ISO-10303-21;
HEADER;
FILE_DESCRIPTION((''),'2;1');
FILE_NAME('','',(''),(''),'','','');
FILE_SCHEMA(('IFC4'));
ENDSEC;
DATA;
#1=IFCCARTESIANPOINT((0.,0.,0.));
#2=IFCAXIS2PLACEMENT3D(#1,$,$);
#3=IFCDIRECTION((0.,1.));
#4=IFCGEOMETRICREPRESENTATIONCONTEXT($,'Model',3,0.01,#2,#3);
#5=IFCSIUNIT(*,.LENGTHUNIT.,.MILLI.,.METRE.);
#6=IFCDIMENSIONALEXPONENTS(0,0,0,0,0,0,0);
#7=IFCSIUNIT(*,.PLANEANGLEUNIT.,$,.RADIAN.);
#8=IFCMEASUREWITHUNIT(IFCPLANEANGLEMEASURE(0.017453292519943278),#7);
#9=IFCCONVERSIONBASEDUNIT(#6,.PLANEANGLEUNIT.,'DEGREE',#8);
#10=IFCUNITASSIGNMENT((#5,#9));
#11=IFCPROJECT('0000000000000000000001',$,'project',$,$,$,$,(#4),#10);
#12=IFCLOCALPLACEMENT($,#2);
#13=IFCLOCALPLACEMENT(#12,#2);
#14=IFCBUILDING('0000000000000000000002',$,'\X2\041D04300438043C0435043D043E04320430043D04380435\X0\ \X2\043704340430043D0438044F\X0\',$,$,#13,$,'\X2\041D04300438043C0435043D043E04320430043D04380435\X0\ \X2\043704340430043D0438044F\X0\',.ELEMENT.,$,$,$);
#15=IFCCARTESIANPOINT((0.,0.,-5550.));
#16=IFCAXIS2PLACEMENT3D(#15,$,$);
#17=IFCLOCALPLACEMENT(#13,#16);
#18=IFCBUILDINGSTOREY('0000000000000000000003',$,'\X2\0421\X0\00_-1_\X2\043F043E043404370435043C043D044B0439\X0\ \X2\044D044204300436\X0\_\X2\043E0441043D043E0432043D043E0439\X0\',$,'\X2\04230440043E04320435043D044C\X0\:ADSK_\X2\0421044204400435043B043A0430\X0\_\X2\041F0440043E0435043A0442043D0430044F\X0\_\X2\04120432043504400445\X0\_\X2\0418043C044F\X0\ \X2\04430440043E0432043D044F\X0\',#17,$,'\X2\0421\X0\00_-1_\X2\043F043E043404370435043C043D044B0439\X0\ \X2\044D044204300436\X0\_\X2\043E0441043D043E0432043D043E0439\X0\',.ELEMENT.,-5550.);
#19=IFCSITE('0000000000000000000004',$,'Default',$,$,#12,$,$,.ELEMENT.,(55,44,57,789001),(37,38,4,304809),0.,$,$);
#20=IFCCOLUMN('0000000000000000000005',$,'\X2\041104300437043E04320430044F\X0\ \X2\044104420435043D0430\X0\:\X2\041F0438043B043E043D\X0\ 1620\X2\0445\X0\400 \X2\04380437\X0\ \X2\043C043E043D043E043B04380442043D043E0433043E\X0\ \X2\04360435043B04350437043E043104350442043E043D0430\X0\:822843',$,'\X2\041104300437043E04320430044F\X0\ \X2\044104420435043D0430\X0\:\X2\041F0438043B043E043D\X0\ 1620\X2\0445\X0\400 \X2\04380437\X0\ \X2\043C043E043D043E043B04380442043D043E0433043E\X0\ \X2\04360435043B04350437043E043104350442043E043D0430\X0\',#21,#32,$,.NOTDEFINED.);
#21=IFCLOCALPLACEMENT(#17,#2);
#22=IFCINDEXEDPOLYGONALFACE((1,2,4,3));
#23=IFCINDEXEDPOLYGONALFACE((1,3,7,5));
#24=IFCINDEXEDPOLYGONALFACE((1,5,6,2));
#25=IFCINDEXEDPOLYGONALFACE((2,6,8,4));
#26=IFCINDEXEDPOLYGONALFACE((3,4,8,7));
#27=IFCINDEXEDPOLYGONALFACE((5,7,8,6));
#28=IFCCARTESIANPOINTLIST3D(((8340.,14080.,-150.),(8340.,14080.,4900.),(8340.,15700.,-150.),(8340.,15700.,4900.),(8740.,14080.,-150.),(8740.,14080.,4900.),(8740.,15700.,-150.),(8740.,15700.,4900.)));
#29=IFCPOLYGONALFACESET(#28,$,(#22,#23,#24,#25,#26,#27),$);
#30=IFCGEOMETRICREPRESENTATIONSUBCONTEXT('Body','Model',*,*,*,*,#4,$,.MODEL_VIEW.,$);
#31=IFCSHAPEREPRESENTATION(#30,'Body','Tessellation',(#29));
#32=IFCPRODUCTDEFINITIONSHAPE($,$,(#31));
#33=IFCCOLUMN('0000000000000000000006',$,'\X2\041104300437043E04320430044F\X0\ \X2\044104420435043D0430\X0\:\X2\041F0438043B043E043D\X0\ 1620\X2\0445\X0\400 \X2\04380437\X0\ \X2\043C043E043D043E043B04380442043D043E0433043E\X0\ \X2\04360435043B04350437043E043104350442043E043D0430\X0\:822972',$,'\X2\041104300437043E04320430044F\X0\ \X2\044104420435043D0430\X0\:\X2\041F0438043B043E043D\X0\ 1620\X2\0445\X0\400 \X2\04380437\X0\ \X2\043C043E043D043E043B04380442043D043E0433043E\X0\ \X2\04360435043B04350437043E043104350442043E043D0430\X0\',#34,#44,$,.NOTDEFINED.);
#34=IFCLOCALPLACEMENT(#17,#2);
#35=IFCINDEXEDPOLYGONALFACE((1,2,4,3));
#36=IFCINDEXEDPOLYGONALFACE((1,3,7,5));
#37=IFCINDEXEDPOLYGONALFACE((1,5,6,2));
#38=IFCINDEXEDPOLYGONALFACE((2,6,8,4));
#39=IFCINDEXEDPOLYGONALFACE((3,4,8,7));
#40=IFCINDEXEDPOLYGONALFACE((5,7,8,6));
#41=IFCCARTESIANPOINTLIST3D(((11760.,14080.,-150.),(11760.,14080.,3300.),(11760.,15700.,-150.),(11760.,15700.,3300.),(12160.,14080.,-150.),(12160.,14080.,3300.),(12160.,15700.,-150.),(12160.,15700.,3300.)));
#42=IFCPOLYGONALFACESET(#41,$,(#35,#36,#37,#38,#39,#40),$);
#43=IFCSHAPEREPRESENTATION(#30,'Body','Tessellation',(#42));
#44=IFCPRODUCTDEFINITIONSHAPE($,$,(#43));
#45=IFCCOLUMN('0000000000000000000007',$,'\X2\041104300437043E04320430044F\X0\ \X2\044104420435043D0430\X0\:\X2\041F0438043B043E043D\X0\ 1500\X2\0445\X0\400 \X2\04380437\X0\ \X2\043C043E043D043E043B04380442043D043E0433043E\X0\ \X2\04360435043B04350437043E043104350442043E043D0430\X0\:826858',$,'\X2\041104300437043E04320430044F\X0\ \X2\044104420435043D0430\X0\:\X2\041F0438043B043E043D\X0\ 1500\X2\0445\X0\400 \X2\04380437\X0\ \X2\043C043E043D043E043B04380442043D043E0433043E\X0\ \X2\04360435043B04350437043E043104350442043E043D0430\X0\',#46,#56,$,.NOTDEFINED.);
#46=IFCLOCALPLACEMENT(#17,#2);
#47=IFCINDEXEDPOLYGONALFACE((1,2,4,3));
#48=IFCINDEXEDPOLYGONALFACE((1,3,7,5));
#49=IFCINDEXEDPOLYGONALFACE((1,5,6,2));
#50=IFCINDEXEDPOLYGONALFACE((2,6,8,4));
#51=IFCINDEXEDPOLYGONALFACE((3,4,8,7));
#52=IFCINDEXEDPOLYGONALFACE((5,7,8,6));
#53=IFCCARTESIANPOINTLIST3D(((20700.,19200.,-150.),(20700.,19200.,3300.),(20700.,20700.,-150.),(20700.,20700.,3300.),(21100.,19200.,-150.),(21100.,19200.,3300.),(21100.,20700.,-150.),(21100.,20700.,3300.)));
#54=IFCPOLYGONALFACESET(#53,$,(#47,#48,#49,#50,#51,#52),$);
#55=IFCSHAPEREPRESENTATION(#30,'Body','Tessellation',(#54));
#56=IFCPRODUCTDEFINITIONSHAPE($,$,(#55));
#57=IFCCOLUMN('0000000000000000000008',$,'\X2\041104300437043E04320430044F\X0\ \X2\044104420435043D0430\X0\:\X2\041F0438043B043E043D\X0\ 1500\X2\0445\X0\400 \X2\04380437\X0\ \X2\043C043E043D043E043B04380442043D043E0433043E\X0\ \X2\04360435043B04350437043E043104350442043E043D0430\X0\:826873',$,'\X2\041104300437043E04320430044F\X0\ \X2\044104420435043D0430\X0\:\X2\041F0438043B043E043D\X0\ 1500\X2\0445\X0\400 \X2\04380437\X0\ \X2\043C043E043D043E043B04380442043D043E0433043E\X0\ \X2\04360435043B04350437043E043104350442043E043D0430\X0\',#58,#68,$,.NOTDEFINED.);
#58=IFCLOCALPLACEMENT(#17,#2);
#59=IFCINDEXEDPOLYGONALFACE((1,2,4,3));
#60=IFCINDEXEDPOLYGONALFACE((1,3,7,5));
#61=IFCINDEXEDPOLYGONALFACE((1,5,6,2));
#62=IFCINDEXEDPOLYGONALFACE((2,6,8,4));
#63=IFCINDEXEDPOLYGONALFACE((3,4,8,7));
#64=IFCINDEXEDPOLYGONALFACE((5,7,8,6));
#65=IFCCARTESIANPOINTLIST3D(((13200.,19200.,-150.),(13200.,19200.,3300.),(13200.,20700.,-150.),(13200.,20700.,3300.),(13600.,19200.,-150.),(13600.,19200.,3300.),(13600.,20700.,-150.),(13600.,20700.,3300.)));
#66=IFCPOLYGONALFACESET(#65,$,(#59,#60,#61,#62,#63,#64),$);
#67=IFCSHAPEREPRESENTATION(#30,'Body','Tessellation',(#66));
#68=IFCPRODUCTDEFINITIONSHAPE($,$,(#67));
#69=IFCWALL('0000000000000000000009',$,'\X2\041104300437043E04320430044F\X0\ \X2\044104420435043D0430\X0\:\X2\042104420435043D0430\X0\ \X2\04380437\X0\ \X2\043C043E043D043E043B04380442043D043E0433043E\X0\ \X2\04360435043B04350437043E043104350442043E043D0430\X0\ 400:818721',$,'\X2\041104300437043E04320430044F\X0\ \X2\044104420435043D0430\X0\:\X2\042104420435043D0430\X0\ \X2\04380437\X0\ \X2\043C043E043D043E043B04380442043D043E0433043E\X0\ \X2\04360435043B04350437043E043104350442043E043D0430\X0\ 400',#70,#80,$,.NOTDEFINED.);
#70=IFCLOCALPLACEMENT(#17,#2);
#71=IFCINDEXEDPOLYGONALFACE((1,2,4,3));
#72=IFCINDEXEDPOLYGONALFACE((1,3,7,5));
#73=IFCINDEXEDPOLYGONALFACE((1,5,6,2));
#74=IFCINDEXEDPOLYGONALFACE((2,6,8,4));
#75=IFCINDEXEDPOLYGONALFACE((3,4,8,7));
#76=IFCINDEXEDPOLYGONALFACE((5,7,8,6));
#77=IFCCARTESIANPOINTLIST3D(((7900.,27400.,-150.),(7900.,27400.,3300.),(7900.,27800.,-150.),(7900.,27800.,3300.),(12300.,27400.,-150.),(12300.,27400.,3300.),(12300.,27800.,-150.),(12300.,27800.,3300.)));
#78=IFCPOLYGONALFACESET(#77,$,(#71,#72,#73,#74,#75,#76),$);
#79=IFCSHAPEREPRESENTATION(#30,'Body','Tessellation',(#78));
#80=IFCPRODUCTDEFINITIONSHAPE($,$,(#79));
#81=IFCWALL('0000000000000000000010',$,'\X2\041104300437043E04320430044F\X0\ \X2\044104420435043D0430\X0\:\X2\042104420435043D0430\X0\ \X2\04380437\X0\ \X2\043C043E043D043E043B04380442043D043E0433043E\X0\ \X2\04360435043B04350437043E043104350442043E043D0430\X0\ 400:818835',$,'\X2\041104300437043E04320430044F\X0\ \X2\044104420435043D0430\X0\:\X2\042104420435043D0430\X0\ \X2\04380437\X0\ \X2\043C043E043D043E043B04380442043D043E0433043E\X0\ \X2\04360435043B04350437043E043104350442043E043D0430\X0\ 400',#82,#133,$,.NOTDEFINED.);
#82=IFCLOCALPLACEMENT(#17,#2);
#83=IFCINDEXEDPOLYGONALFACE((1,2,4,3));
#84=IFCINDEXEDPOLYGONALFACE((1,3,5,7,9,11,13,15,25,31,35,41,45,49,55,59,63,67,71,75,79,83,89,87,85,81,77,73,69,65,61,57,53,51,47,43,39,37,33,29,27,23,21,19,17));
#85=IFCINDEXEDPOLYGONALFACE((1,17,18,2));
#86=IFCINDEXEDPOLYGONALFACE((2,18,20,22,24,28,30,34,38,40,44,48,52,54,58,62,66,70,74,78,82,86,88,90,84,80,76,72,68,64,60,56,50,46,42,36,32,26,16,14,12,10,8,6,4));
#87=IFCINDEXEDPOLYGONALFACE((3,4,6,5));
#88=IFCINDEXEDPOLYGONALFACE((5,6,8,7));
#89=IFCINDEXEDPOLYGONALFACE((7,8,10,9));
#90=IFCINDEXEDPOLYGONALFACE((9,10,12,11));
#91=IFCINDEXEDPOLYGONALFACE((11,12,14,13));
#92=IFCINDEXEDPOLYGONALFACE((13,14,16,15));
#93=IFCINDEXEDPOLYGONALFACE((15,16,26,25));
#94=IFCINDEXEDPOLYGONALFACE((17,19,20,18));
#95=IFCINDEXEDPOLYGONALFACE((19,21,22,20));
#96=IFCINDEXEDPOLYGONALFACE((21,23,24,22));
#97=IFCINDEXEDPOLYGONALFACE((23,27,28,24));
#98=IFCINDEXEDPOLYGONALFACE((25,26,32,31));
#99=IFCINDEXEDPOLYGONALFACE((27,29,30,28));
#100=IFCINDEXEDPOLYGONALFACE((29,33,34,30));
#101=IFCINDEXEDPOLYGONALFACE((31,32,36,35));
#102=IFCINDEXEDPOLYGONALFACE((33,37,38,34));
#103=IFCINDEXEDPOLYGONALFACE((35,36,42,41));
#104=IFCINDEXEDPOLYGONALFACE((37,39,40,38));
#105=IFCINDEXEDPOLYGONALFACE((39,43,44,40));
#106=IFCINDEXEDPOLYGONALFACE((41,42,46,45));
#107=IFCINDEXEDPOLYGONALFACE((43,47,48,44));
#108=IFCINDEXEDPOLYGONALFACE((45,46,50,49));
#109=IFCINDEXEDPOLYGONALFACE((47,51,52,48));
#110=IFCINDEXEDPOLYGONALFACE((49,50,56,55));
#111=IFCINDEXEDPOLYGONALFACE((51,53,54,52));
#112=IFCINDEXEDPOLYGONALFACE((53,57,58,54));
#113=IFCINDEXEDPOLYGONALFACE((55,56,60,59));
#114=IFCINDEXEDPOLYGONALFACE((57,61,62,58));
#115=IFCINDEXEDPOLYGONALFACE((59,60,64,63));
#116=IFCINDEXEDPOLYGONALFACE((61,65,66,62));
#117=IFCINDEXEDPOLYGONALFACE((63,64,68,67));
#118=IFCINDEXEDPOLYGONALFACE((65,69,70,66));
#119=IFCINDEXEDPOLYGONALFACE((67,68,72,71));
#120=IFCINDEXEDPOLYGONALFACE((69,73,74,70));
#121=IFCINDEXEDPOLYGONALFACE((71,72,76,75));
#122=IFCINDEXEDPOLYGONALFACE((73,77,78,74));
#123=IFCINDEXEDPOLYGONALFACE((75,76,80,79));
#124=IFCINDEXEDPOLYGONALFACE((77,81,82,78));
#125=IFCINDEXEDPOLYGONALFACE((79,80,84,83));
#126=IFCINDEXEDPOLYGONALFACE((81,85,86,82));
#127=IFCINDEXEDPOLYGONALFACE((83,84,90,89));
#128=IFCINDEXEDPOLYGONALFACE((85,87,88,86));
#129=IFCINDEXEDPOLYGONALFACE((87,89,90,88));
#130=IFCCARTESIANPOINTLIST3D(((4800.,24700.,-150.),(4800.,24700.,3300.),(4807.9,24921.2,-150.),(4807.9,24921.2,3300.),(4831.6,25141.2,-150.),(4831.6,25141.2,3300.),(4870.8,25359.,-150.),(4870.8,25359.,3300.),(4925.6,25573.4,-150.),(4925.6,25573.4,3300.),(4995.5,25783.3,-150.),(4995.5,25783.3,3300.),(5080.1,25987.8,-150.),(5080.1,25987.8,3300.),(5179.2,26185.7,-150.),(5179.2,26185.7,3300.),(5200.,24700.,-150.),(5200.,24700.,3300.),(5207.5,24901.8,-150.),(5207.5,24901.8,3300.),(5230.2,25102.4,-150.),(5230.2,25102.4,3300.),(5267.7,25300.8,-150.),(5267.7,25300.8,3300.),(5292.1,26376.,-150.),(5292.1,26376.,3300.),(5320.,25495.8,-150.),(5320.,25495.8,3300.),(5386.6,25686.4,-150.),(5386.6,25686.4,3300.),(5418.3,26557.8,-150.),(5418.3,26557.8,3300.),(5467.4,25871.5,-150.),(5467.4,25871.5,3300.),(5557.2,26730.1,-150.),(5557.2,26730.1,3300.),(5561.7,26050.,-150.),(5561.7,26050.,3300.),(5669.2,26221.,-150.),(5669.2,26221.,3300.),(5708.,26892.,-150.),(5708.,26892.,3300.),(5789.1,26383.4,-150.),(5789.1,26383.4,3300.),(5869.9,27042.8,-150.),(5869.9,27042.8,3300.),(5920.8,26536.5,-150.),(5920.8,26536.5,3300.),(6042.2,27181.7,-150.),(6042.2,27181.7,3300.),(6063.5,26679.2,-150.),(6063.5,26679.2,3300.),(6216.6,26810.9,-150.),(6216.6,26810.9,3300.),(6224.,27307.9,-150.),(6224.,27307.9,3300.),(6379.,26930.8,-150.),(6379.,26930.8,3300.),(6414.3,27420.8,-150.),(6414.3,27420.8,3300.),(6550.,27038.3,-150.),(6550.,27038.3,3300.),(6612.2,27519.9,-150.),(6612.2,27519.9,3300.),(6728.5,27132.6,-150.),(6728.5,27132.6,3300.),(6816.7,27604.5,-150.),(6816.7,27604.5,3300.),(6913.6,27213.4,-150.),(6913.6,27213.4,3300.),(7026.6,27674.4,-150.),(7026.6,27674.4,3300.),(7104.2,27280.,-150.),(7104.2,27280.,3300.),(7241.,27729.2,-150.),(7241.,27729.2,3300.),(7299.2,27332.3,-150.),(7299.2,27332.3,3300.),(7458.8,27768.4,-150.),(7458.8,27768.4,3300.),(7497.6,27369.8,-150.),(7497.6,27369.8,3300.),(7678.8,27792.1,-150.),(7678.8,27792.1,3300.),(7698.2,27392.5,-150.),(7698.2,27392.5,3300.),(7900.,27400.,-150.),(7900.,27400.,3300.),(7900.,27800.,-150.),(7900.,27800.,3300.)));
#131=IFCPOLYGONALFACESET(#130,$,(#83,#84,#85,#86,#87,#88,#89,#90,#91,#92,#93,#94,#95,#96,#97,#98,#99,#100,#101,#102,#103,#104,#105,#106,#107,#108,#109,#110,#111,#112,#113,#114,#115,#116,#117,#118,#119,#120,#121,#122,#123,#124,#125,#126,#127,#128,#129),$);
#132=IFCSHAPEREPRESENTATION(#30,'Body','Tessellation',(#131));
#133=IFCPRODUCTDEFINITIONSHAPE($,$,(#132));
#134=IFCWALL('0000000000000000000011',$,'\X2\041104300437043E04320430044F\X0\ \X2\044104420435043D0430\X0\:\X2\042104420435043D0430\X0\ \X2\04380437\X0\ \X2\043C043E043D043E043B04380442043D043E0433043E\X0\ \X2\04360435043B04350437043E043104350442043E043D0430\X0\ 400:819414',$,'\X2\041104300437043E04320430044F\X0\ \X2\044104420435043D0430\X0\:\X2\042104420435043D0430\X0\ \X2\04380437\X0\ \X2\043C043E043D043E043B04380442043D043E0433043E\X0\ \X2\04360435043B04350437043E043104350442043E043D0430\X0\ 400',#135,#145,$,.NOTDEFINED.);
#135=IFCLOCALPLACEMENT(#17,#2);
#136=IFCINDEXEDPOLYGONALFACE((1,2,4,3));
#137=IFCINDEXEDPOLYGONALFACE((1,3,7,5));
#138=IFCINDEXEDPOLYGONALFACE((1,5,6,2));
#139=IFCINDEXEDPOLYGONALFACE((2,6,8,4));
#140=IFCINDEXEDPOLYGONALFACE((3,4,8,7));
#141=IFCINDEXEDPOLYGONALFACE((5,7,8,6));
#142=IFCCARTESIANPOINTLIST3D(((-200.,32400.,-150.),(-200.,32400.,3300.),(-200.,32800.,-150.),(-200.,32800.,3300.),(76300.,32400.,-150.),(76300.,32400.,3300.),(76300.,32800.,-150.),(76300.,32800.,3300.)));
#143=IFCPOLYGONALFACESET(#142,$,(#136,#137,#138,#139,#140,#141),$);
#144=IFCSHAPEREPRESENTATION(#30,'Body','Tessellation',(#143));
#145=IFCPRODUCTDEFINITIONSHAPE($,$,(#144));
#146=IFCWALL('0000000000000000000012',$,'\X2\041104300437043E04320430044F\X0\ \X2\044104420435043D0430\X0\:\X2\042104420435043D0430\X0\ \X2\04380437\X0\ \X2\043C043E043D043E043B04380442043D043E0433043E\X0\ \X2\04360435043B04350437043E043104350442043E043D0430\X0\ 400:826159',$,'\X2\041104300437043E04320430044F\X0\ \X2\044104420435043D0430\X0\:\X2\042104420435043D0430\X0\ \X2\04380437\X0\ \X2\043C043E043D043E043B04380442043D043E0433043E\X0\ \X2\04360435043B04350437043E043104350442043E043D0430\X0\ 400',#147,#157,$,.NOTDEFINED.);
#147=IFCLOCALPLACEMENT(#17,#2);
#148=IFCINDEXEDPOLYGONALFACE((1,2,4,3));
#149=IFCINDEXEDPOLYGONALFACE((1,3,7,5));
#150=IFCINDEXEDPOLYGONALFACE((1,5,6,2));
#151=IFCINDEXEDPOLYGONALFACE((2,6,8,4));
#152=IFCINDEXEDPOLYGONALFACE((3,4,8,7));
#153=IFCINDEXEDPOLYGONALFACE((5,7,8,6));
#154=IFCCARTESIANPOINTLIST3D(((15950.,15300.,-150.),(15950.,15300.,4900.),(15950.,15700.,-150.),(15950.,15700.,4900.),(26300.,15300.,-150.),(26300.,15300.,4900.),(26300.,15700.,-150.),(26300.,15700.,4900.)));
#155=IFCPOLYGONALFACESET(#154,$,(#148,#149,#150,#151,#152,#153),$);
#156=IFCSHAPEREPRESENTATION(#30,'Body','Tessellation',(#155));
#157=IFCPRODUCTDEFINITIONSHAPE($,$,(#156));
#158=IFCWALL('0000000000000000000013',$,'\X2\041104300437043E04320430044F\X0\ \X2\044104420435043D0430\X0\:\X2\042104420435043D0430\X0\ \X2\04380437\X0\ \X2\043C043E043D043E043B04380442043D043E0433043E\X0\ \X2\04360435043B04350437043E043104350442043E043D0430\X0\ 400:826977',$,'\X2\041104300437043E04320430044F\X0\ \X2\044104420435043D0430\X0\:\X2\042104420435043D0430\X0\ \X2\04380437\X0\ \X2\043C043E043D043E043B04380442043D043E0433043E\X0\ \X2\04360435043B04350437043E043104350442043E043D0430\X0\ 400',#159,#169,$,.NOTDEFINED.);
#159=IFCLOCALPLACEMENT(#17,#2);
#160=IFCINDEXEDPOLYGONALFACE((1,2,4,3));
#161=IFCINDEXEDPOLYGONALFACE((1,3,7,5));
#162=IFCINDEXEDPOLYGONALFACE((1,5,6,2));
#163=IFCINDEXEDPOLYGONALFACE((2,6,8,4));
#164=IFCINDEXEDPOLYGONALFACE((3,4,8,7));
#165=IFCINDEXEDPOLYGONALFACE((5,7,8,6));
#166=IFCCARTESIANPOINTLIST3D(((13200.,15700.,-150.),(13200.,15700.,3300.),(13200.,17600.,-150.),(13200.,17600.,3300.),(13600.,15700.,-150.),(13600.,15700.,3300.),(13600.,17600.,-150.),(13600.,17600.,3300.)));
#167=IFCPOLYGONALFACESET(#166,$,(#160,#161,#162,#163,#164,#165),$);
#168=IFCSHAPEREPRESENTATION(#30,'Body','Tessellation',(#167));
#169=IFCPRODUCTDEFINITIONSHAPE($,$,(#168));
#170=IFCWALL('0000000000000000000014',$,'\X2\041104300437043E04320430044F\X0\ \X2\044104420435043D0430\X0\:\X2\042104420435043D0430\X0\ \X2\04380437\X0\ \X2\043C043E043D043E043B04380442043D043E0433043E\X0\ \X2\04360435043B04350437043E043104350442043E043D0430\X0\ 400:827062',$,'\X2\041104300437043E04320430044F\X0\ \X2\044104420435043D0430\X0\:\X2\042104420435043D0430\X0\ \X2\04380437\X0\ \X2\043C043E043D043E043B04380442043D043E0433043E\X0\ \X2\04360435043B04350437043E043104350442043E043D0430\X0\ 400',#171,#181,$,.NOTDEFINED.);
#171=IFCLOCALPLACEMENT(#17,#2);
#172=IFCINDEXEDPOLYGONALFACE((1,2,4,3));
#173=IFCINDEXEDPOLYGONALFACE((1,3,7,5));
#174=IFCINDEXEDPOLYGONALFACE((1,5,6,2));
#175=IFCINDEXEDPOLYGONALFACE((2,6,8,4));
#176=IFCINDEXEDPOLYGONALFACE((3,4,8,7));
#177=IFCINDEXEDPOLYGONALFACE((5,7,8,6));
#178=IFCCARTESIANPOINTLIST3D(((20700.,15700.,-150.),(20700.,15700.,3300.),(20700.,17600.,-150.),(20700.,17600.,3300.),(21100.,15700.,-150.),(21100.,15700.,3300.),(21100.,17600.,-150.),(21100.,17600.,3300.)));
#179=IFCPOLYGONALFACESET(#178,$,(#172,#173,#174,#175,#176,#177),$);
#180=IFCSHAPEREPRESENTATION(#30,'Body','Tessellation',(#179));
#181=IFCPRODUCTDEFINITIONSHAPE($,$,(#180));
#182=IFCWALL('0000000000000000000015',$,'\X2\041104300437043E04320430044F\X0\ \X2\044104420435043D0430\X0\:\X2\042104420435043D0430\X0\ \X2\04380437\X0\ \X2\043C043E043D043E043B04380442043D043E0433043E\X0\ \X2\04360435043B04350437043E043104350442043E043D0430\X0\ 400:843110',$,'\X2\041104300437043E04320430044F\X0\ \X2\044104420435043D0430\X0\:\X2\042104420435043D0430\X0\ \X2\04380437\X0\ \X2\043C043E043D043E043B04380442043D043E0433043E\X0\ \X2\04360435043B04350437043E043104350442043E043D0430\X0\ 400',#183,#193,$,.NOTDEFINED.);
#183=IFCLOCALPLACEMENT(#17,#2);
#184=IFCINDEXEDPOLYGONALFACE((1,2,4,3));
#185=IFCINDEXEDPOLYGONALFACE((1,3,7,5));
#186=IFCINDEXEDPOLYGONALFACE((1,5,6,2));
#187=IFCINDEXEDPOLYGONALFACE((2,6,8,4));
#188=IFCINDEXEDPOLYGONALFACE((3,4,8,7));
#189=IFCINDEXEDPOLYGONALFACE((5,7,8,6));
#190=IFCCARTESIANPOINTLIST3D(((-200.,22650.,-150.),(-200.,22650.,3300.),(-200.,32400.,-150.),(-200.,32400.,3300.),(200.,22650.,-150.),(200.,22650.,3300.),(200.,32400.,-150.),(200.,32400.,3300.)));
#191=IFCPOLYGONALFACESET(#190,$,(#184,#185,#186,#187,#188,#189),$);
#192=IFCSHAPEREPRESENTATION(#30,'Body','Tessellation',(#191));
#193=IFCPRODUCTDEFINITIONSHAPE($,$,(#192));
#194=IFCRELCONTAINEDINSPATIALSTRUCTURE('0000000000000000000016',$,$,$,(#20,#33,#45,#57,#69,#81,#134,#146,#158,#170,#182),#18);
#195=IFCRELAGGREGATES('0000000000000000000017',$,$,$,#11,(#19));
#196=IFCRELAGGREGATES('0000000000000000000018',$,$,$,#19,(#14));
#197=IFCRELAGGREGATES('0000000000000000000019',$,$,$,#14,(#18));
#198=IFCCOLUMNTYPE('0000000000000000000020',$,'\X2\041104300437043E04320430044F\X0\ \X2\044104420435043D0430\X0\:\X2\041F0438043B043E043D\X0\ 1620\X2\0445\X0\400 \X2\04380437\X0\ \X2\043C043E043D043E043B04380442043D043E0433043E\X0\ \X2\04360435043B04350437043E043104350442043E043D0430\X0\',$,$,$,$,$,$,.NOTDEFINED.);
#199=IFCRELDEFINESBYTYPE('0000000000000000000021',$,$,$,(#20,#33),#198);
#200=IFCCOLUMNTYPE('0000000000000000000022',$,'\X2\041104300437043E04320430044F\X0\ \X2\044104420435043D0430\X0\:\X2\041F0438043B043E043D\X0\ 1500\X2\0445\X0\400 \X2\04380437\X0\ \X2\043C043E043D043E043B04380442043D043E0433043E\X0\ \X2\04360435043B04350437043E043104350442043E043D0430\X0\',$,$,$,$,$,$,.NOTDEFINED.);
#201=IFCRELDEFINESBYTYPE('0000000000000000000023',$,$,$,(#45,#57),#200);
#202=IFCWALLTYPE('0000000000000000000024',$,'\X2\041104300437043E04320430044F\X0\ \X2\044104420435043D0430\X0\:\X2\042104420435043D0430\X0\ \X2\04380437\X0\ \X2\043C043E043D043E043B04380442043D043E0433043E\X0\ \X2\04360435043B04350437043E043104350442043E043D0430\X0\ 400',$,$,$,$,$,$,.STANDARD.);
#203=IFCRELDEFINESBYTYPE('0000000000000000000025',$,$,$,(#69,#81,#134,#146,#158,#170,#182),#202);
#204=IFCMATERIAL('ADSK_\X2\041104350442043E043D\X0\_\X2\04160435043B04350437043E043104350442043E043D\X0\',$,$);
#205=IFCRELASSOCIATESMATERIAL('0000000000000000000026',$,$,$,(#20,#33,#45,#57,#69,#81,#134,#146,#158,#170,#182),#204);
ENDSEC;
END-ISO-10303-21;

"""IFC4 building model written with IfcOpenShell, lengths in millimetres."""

from ifc_helpers import new_model, entity, si_unit, converted_unit, direction, frame, origin, place, context, subcontext, project, spatial, line, arc, indexed_curve, outline, extrude, material, type_object, element, save


model = new_model("IFC4")

# Units and contexts
model_context = context("Model", 3, precision=0.01, world=origin(), true_north=direction((0.0, 1.0)))
body_context = subcontext(model_context, "Body", "Model", "MODEL_VIEW")
ifc_project = project(units=[si_unit("LENGTHUNIT", "METRE", prefix="MILLI"), converted_unit("PLANEANGLEUNIT", "DEGREE", entity("IfcPlaneAngleMeasure", 0.017453292519943278), si_unit("PLANEANGLEUNIT", "RADIAN"), dimensions=[0, 0, 0, 0, 0, 0, 0])], contexts=[model_context])

# Site, building, storey
site_placement = place(None, origin())
site = spatial("IfcSite", under=ifc_project, at=site_placement, Name="Default", CompositionType="ELEMENT", RefLatitude=(55, 44, 57, 789001), RefLongitude=(37, 38, 4, 304809), RefElevation=0.0)
building_placement = place(site_placement, origin())
building = spatial("IfcBuilding", under=site, at=building_placement, Name="Наименование здания", LongName="Наименование здания", CompositionType="ELEMENT")
storey_placement = place(building_placement, frame((0.0, 0.0, -5550.0)))
storey = spatial("IfcBuildingStorey", under=building, at=storey_placement, Name="С00_-1_подземный этаж_основной", ObjectType="Уровень:ADSK_Стрелка_Проектная_Вверх_Имя уровня", LongName="С00_-1_подземный этаж_основной", CompositionType="ELEMENT", Elevation=-5550.0)

# Columns
ifc_material_1 = material(Name="ADSK_Бетон_Железобетон")
column_type_1 = type_object("IfcColumnType", Name="Базовая стена:Пилон 1620х400 из монолитного железобетона", PredefinedType="NOTDEFINED")
column_1_placement = place(storey_placement, frame((8540.0, 14080.0, -150.0), z_axis=(0.0, 0.0, 1.0), x_axis=(0.0, 1.0, 0.0)))
element("IfcColumn", 1, at=column_1_placement, inside=storey, type_object=column_type_1, material=ifc_material_1, Name="Базовая стена:Пилон 1620х400 из монолитного железобетона:822843", ObjectType="Базовая стена:Пилон 1620х400 из монолитного железобетона", PredefinedType="NOTDEFINED", context=body_context, shape_type="SweptSolid", body=[
    extrude(outline(indexed_curve([(1620.0, 200.0), (0.0, 200.0), (0.0, -200.0), (1620.0, -200.0), (1620.0, 200.0)], self_intersect=False)), origin(), (0.0, 0.0, 1.0), 5050.0),
])
column_2_placement = place(storey_placement, frame((11960.0, 14080.0, -150.0), z_axis=(0.0, 0.0, 1.0), x_axis=(0.0, 1.0, 0.0)))
element("IfcColumn", 2, at=column_2_placement, inside=storey, type_object=column_type_1, material=ifc_material_1, Name="Базовая стена:Пилон 1620х400 из монолитного железобетона:822972", ObjectType="Базовая стена:Пилон 1620х400 из монолитного железобетона", PredefinedType="NOTDEFINED", context=body_context, shape_type="SweptSolid", body=[
    extrude(outline(indexed_curve([(1620.0, 200.0), (0.0, 200.0), (0.0, -200.0), (1620.0, -200.0), (1620.0, 200.0)], self_intersect=False)), origin(), (0.0, 0.0, 1.0), 3450.0),
])
column_type_2 = type_object("IfcColumnType", Name="Базовая стена:Пилон 1500х400 из монолитного железобетона", PredefinedType="NOTDEFINED")
column_3_placement = place(storey_placement, frame((20900.0, 19200.0, -150.0), z_axis=(0.0, 0.0, 1.0), x_axis=(0.0, 1.0, 0.0)))
element("IfcColumn", 3, at=column_3_placement, inside=storey, type_object=column_type_2, material=ifc_material_1, Name="Базовая стена:Пилон 1500х400 из монолитного железобетона:826858", ObjectType="Базовая стена:Пилон 1500х400 из монолитного железобетона", PredefinedType="NOTDEFINED", context=body_context, shape_type="SweptSolid", body=[
    extrude(outline(indexed_curve([(1500.0, 200.0), (0.0, 200.0), (0.0, -200.0), (1500.0, -200.0), (1500.0, 200.0)], self_intersect=False)), origin(), (0.0, 0.0, 1.0), 3450.0),
])
column_4_placement = place(storey_placement, frame((13400.0, 19200.0, -150.0), z_axis=(0.0, 0.0, 1.0), x_axis=(0.0, 1.0, 0.0)))
element("IfcColumn", 4, at=column_4_placement, inside=storey, type_object=column_type_2, material=ifc_material_1, Name="Базовая стена:Пилон 1500х400 из монолитного железобетона:826873", ObjectType="Базовая стена:Пилон 1500х400 из монолитного железобетона", PredefinedType="NOTDEFINED", context=body_context, shape_type="SweptSolid", body=[
    extrude(outline(indexed_curve([(1500.0, 200.0), (0.0, 200.0), (0.0, -200.0), (1500.0, -200.0), (1500.0, 200.0)], self_intersect=False)), origin(), (0.0, 0.0, 1.0), 3450.0),
])

# Walls
wall_type_1 = type_object("IfcWallType", Name="Базовая стена:Стена из монолитного железобетона 400", PredefinedType="STANDARD")
wall_1_placement = place(storey_placement, frame((12300.0, 27600.0, -150.0), z_axis=(0.0, 0.0, 1.0), x_axis=(-1.0, 0.0, 0.0)))
element("IfcWall", 5, at=wall_1_placement, inside=storey, type_object=wall_type_1, material=ifc_material_1, Name="Базовая стена:Стена из монолитного железобетона 400:818721", ObjectType="Базовая стена:Стена из монолитного железобетона 400", PredefinedType="NOTDEFINED", context=body_context, shape_type="SweptSolid", body=[
    extrude(outline(indexed_curve([(4400.0, 200.0), (0.0, 200.0), (0.0, -200.0), (4400.0, -200.0), (4400.0, 200.0)], self_intersect=False)), origin(), (0.0, 0.0, 1.0), 3450.0),
])
wall_2_placement = place(storey_placement, frame((5000.0, 24700.0, -150.0)))
element("IfcWall", 6, at=wall_2_placement, inside=storey, type_object=wall_type_1, material=ifc_material_1, Name="Базовая стена:Стена из монолитного железобетона 400:818835", ObjectType="Базовая стена:Стена из монолитного железобетона 400", PredefinedType="NOTDEFINED", context=body_context, shape_type="SweptSolid", body=[
    extrude(outline(indexed_curve([(2900.0, 3100.0), (708.0, 2192.0), (-200.0, 0.0), (200.0, 0.0), (990.8, 1909.2), (2900.0, 2700.0)], segments=[arc(1, 2, 3), line(3, 4), arc(4, 5, 6), line(6, 1)], self_intersect=False)), origin(), (0.0, 0.0, 1.0), 3450.0),
])
wall_3_placement = place(storey_placement, frame((-200.0, 32600.0, -150.0)))
element("IfcWall", 7, at=wall_3_placement, inside=storey, type_object=wall_type_1, material=ifc_material_1, Name="Базовая стена:Стена из монолитного железобетона 400:819414", ObjectType="Базовая стена:Стена из монолитного железобетона 400", PredefinedType="NOTDEFINED", context=body_context, shape_type="SweptSolid", body=[
    extrude(outline(indexed_curve([(76500.0, 200.0), (0.0, 200.0), (0.0, -200.0), (76500.0, -200.0), (76500.0, 200.0)], self_intersect=False)), origin(), (0.0, 0.0, 1.0), 3450.0),
])
wall_4_placement = place(storey_placement, frame((15950.0, 15500.0, -150.0)))
element("IfcWall", 8, at=wall_4_placement, inside=storey, type_object=wall_type_1, material=ifc_material_1, Name="Базовая стена:Стена из монолитного железобетона 400:826159", ObjectType="Базовая стена:Стена из монолитного железобетона 400", PredefinedType="NOTDEFINED", context=body_context, shape_type="SweptSolid", body=[
    extrude(outline(indexed_curve([(10350.0, 200.0), (0.0, 200.0), (0.0, -200.0), (10350.0, -200.0), (10350.0, 200.0)], self_intersect=False)), origin(), (0.0, 0.0, 1.0), 5050.0),
])
wall_5_placement = place(storey_placement, frame((13400.0, 17600.0, -150.0), z_axis=(0.0, 0.0, 1.0), x_axis=(0.0, -1.0, 0.0)))
element("IfcWall", 9, at=wall_5_placement, inside=storey, type_object=wall_type_1, material=ifc_material_1, Name="Базовая стена:Стена из монолитного железобетона 400:826977", ObjectType="Базовая стена:Стена из монолитного железобетона 400", PredefinedType="NOTDEFINED", context=body_context, shape_type="SweptSolid", body=[
    extrude(outline(indexed_curve([(1900.0, 200.0), (0.0, 200.0), (0.0, -200.0), (1900.0, -200.0), (1900.0, 200.0)], self_intersect=False)), origin(), (0.0, 0.0, 1.0), 3450.0),
])
wall_6_placement = place(storey_placement, frame((20900.0, 17600.0, -150.0), z_axis=(0.0, 0.0, 1.0), x_axis=(0.0, -1.0, 0.0)))
element("IfcWall", 10, at=wall_6_placement, inside=storey, type_object=wall_type_1, material=ifc_material_1, Name="Базовая стена:Стена из монолитного железобетона 400:827062", ObjectType="Базовая стена:Стена из монолитного железобетона 400", PredefinedType="NOTDEFINED", context=body_context, shape_type="SweptSolid", body=[
    extrude(outline(indexed_curve([(1900.0, 200.0), (0.0, 200.0), (0.0, -200.0), (1900.0, -200.0), (1900.0, 200.0)], self_intersect=False)), origin(), (0.0, 0.0, 1.0), 3450.0),
])
wall_7_placement = place(storey_placement, frame((0.0, 22650.0, -150.0), z_axis=(0.0, 0.0, 1.0), x_axis=(0.0, 1.0, 0.0)))
element("IfcWall", 11, at=wall_7_placement, inside=storey, type_object=wall_type_1, material=ifc_material_1, Name="Базовая стена:Стена из монолитного железобетона 400:843110", ObjectType="Базовая стена:Стена из монолитного железобетона 400", PredefinedType="NOTDEFINED", context=body_context, shape_type="SweptSolid", body=[
    extrude(outline(indexed_curve([(9750.0, 200.0), (0.0, 200.0), (0.0, -200.0), (9750.0, -200.0), (9750.0, 200.0)], self_intersect=False)), origin(), (0.0, 0.0, 1.0), 3450.0),
])

save(model, "model.ifc")
